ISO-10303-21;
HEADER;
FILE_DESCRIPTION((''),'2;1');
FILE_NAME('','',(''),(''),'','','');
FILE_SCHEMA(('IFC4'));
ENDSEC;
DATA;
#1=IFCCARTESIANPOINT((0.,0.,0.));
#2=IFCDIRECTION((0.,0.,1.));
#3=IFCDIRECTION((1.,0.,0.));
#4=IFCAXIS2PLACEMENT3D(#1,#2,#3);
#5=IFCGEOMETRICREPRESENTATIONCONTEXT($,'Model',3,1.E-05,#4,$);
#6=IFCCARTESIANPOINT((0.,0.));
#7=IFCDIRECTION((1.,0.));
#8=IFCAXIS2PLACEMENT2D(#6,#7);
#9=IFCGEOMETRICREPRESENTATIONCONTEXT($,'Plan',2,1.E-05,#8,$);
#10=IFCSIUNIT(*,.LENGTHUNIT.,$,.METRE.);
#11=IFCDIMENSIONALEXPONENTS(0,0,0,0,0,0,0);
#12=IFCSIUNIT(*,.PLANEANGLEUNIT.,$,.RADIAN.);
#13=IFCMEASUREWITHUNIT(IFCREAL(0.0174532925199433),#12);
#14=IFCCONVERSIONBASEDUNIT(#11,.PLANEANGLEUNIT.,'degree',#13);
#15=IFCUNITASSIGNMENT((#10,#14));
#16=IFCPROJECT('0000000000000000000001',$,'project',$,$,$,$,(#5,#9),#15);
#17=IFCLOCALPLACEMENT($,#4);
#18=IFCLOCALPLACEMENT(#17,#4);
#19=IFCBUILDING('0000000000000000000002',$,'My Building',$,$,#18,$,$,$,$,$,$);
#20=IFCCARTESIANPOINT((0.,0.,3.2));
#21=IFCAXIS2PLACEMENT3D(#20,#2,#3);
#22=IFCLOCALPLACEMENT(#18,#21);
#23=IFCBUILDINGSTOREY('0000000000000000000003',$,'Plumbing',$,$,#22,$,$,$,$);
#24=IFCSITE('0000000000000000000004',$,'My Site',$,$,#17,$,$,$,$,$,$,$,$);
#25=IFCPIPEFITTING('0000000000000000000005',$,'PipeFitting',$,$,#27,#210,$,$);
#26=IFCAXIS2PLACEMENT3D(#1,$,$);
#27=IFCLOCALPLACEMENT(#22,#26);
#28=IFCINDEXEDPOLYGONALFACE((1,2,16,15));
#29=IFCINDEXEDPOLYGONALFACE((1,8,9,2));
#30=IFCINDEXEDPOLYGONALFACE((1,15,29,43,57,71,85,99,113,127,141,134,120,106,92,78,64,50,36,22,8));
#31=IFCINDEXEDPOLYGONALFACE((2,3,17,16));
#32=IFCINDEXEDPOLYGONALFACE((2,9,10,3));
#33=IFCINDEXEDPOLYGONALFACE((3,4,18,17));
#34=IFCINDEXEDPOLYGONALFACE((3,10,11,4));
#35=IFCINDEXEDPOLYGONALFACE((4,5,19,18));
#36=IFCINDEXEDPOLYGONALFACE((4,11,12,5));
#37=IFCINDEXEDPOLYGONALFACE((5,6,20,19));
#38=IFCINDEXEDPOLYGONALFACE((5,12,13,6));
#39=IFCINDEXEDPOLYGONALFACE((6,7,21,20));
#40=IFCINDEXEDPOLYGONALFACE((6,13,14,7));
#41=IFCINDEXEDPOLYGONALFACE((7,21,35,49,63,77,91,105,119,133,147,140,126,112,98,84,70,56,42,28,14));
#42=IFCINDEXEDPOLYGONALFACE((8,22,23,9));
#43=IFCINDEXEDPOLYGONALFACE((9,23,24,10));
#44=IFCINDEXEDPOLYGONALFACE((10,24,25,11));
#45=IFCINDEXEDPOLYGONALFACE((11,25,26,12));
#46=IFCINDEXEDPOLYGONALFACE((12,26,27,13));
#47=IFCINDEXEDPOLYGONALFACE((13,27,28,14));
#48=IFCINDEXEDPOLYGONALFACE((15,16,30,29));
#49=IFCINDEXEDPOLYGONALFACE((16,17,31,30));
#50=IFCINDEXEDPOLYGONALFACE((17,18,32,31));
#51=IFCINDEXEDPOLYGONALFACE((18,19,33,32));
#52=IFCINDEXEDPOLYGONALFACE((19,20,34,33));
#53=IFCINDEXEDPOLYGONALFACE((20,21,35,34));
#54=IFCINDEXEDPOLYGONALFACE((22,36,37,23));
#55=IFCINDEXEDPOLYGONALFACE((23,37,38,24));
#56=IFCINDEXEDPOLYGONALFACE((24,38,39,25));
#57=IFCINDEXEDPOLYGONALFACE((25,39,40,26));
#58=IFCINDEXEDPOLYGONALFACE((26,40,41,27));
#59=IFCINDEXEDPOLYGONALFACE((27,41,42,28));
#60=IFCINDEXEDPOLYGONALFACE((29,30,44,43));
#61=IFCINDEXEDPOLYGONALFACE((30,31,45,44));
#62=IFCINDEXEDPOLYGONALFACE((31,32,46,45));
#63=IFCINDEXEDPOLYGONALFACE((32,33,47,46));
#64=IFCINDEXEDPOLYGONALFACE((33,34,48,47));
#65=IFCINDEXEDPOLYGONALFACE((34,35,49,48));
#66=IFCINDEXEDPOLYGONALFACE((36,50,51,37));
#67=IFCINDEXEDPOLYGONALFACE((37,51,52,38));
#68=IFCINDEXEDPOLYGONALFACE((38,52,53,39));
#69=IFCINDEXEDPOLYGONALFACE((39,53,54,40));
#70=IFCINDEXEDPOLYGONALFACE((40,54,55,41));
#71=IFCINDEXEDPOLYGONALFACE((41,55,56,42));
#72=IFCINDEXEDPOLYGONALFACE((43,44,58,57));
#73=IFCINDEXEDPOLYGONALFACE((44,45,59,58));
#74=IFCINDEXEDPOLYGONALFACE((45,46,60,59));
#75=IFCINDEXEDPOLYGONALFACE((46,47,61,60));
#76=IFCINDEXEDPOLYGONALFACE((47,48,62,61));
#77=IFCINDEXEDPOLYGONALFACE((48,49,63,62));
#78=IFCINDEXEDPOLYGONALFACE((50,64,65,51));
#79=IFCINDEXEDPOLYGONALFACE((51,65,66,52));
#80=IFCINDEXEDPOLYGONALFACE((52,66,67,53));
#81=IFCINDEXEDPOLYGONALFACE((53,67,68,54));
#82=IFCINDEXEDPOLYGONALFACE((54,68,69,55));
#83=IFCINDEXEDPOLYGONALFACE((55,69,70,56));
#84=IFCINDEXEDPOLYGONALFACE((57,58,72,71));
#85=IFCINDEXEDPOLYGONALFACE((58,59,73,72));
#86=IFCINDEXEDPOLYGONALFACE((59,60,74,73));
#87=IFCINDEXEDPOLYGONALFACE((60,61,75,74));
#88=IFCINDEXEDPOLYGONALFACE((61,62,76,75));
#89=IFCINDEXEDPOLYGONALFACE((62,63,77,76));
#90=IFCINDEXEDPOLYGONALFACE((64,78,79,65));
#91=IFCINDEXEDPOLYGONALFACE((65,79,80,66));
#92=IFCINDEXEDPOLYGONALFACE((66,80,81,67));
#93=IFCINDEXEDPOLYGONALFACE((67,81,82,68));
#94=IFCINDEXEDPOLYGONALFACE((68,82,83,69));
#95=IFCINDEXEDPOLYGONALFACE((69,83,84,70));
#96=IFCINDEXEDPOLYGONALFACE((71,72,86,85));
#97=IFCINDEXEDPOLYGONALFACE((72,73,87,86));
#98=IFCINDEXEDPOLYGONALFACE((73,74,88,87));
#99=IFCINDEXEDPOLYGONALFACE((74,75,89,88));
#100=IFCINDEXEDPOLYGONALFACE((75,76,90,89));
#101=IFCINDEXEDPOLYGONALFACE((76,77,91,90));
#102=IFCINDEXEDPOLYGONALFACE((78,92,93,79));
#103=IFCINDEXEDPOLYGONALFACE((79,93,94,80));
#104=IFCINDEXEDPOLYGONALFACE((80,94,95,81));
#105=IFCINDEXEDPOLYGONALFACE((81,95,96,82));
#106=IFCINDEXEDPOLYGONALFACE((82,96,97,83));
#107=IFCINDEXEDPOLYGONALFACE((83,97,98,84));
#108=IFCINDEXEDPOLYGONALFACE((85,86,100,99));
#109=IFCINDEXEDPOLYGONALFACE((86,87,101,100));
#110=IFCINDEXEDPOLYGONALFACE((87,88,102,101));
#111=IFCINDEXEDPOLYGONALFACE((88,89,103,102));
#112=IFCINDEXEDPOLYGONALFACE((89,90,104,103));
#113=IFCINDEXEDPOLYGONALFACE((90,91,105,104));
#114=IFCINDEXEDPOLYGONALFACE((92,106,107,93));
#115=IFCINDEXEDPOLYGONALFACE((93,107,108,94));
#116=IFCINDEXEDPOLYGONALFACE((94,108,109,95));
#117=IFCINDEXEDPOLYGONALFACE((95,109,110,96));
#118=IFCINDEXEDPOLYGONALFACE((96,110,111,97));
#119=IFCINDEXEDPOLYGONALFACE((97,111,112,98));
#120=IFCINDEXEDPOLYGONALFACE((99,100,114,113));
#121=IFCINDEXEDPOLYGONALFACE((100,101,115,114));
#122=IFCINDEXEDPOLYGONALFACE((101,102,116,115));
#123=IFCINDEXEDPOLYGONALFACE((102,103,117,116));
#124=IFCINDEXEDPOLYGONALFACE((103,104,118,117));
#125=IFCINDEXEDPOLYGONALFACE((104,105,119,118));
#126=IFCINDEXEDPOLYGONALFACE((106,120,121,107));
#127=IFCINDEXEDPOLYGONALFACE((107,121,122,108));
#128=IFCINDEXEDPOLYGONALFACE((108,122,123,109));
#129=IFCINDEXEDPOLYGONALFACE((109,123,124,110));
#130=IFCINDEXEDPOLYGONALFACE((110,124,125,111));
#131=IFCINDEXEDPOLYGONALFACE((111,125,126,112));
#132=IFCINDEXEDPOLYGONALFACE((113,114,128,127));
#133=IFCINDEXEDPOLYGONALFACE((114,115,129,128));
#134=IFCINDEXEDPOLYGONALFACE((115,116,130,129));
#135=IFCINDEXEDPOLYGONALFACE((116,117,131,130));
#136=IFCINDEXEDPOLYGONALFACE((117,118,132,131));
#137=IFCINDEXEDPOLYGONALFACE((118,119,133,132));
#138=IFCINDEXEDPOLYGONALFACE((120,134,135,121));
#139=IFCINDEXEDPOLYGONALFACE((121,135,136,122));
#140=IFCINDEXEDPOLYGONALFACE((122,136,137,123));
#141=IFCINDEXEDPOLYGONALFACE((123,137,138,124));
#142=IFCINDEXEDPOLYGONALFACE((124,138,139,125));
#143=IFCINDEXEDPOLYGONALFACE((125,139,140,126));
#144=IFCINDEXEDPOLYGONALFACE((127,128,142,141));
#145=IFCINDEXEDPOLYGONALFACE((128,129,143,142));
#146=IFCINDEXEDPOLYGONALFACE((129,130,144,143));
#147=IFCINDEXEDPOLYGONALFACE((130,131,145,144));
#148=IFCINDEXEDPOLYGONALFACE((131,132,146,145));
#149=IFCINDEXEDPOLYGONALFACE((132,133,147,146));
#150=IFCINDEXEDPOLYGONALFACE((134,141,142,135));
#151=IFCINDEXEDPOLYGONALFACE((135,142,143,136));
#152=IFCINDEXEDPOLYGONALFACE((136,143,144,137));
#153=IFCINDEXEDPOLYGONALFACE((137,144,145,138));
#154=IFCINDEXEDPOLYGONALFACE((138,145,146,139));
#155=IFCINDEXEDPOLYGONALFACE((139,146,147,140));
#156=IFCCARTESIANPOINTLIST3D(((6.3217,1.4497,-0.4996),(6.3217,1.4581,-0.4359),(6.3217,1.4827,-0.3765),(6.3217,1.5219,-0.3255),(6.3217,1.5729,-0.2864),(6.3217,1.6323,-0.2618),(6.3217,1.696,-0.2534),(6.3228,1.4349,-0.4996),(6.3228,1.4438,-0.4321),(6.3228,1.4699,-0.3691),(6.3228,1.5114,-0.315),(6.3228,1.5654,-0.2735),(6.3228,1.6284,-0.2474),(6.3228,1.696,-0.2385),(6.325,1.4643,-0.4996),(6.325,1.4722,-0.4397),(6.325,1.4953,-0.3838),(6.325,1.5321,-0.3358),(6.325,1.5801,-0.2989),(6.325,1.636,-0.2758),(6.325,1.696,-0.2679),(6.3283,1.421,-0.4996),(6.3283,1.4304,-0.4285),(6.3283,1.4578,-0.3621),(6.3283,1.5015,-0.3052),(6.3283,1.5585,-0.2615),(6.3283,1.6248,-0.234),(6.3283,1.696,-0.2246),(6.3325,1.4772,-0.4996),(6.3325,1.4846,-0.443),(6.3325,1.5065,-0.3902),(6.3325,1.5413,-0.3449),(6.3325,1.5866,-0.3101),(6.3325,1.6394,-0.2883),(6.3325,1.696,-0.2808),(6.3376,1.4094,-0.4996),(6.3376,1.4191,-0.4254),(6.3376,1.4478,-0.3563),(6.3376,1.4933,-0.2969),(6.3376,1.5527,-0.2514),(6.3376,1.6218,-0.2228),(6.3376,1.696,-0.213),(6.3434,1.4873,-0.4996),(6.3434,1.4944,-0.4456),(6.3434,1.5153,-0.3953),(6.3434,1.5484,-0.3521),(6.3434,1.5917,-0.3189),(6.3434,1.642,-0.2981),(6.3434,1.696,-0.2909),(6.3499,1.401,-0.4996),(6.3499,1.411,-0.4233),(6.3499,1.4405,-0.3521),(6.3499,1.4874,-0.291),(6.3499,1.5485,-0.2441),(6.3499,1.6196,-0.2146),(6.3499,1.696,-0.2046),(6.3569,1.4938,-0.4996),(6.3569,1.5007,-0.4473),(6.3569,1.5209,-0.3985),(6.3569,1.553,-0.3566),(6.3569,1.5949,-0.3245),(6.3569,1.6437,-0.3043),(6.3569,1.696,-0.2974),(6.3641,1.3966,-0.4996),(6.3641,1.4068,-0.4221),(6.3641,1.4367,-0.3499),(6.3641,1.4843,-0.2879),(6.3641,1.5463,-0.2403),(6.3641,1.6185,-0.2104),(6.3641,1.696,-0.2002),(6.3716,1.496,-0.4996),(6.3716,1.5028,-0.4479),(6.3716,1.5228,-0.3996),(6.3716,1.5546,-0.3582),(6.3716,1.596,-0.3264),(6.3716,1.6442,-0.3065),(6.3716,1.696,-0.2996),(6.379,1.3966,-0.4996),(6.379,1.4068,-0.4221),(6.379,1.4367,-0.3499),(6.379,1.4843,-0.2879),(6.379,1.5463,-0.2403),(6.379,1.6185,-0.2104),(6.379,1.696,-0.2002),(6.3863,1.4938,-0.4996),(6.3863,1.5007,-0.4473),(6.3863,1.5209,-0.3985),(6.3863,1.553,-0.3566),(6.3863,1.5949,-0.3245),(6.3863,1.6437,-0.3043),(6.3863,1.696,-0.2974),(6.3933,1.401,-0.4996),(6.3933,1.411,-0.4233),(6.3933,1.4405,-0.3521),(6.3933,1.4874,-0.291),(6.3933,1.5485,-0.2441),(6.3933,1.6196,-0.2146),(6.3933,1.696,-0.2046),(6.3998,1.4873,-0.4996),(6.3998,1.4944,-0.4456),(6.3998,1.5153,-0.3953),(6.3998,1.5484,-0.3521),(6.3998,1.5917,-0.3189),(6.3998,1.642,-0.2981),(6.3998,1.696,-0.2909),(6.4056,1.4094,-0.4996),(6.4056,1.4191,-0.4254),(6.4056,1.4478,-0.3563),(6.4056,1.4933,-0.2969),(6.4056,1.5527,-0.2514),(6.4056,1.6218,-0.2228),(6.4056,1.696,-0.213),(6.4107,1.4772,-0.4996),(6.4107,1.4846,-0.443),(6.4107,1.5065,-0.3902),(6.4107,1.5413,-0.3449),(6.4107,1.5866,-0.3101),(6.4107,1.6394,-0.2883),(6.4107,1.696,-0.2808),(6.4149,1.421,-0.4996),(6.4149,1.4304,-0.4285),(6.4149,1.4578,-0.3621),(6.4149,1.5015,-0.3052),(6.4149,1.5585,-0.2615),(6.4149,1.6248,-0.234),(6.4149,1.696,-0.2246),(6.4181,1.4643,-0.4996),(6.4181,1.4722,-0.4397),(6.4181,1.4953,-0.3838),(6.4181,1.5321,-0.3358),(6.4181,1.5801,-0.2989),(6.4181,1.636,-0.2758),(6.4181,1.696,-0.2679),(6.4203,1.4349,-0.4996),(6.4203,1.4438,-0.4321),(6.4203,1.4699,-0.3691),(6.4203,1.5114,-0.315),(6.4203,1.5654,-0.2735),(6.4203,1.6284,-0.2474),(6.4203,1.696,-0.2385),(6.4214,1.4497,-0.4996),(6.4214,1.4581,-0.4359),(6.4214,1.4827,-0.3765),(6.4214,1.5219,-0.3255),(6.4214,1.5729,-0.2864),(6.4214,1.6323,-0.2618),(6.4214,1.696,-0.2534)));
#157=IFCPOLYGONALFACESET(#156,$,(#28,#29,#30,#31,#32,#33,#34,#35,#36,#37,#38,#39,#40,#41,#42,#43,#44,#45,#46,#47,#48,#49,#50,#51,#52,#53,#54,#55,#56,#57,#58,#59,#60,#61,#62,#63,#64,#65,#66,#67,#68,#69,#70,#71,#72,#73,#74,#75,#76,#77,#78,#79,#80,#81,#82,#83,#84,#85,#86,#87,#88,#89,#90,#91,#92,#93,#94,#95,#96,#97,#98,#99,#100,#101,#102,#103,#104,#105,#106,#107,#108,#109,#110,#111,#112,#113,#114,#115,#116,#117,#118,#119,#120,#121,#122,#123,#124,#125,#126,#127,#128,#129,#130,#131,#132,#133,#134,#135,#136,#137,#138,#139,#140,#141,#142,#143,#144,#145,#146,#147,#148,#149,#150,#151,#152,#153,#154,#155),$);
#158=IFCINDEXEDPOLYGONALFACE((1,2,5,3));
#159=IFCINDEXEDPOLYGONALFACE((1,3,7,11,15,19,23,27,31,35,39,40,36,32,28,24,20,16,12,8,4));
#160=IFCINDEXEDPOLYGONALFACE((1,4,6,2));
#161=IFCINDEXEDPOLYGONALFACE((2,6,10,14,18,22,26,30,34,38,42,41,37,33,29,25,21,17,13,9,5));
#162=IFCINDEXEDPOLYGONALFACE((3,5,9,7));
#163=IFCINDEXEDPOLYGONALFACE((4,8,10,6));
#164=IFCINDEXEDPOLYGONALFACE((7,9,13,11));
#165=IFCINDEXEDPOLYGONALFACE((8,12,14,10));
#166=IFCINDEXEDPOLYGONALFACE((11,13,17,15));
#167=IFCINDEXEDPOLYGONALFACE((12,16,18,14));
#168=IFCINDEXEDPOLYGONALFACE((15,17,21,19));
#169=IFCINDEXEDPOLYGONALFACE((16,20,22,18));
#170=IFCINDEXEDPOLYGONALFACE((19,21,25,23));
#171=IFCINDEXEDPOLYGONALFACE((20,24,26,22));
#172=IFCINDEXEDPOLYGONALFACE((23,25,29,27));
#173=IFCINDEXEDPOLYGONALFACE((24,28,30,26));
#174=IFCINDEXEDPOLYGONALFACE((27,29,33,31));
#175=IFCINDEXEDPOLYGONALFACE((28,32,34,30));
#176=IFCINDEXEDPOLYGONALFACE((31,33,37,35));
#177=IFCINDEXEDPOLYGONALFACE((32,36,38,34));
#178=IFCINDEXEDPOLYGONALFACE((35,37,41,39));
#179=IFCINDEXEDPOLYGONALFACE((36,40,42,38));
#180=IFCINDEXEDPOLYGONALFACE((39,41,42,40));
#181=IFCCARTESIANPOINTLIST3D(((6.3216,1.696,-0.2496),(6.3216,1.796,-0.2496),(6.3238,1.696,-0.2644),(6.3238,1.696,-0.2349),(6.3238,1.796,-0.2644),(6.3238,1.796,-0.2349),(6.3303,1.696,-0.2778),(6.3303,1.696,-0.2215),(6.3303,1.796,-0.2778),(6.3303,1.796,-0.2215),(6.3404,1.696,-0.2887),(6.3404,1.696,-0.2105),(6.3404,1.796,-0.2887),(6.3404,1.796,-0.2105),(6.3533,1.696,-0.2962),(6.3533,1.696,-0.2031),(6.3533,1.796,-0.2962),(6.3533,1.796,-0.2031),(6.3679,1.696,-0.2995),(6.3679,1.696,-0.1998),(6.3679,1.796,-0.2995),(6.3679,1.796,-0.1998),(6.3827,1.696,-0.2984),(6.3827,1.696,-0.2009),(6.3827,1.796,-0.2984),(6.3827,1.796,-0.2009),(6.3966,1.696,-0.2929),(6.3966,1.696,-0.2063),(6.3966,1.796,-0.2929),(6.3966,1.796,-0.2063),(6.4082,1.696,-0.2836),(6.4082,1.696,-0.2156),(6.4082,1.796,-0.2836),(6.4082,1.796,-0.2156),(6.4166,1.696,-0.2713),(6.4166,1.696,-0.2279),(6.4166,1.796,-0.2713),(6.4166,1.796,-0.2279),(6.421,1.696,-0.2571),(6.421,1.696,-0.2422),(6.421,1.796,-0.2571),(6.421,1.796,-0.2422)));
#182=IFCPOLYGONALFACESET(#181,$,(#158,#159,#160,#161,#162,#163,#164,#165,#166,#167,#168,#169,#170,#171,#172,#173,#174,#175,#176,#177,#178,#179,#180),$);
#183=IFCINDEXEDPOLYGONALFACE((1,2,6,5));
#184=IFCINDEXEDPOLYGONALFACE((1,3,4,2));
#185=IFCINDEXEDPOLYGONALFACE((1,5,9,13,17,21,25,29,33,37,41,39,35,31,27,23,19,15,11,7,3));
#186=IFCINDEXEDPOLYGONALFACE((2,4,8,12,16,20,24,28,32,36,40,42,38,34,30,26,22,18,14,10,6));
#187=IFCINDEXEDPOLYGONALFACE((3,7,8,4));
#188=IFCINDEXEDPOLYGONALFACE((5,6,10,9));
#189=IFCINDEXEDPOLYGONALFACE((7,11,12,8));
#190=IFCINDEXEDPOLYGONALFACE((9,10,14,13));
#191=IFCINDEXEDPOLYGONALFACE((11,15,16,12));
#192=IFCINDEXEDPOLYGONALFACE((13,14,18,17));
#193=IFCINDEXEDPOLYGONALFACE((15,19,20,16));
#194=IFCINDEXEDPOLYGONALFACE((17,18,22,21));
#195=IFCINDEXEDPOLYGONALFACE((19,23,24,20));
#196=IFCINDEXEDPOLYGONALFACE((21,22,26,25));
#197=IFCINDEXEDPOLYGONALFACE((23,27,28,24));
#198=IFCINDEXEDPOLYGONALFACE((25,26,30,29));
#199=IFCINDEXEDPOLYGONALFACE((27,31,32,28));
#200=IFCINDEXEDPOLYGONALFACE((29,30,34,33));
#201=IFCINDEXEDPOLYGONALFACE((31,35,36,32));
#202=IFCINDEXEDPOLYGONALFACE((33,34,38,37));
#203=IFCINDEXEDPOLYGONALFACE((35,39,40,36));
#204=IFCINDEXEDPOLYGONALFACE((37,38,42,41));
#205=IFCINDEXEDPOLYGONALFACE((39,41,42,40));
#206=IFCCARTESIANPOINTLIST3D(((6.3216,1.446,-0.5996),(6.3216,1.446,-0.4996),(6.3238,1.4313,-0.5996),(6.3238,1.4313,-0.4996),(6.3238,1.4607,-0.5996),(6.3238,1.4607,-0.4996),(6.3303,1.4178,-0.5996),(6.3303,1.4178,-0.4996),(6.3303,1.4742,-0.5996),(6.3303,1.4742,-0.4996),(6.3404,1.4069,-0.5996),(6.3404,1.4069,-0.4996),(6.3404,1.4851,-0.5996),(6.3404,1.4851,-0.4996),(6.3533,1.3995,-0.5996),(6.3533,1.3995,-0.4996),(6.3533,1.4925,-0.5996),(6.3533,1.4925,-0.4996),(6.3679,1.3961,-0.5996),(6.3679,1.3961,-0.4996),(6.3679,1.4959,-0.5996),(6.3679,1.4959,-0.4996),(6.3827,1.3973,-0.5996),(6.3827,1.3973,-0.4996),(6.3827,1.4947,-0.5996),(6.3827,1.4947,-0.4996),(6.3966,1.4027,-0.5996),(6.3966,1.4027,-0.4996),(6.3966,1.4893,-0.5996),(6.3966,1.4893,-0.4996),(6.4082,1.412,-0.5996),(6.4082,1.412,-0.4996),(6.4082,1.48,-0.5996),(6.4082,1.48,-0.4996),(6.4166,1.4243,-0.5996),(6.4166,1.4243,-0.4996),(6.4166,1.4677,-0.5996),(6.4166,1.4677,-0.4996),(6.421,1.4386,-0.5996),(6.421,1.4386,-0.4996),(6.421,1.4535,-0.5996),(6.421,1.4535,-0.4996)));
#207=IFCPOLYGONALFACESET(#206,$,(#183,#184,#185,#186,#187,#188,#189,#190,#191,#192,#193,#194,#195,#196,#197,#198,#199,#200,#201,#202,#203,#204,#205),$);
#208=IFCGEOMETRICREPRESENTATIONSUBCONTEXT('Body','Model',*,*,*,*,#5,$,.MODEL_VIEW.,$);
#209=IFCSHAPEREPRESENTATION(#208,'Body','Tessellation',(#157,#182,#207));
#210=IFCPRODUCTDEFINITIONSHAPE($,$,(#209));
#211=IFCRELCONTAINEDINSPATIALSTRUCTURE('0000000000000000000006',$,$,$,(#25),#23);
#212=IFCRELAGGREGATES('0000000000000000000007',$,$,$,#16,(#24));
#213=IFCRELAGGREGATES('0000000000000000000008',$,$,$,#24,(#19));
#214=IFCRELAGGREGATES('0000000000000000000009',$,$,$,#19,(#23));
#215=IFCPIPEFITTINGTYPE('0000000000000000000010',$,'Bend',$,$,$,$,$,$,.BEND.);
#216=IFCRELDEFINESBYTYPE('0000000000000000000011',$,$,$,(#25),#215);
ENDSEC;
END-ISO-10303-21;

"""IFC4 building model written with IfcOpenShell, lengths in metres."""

from ifc_helpers import new_model, entity, si_unit, converted_unit, frame, origin_with_axes, origin_2d_with_axis, place, context, subcontext, project, spatial, circle, extrude, source, transform, mapped, type_object, type_shapes, element, save


model = new_model("IFC4")

# Units and contexts
model_context = context("Model", 3, precision=1e-05, world=origin_with_axes())
plan_context = context("Plan", 2, precision=1e-05, world=origin_2d_with_axis())
body_context = subcontext(model_context, "Body", "Model", "MODEL_VIEW")
ifc_project = project(units=[si_unit("LENGTHUNIT", "METRE"), converted_unit("PLANEANGLEUNIT", "degree", entity("IfcReal", 0.0174532925199433), si_unit("PLANEANGLEUNIT", "RADIAN"), dimensions=[0, 0, 0, 0, 0, 0, 0])], contexts=[model_context, plan_context])

# Site, building, storey
site_placement = place(None, origin_with_axes())
site = spatial("IfcSite", under=ifc_project, at=site_placement, Name="My Site")
building_placement = place(site_placement, origin_with_axes())
building = spatial("IfcBuilding", under=site, at=building_placement, Name="My Building")
storey_placement = place(building_placement, frame((0.0, 0.0, 3.2), z_axis=(0.0, 0.0, 1.0), x_axis=(1.0, 0.0, 0.0)))
storey = spatial("IfcBuildingStorey", under=building, at=storey_placement, Name="Plumbing")

# Pipe fitting
pipe_fitting_type = type_object("IfcPipeFittingType", Name="Bend", PredefinedType="BEND")
shared_shape = source(origin_with_axes(), body_context, "Body", "SolidModel", [
    entity("IfcSweptDiskSolid", entity("IfcIndexedPolyCurve", entity("IfcCartesianPointList3D", [[0.0, 0.0, -0.1], [0.0, -0.0732, -0.2768], [0.0, -0.25, -0.35]]), [entity("IfcArcIndex", [1, 2, 3])]), 0.05),
    extrude(circle(Radius=0.05), origin_with_axes(), (0.0, 0.0, -1.0), 0.1),
    extrude(circle(Radius=0.05), frame((0.0, -0.25, -0.35), z_axis=(0.0, -1.0, 0.0), x_axis=(1.0, 0.0, 0.0)), (0.0, 0.0, 1.0), 0.1),
])
type_shapes(pipe_fitting_type, [shared_shape])
for number, where, z_axis, x_axis, name in (
    (1, (6.3716, 1.796, -0.2496), (0.0, 1.0, 0.0), (-1.0, 0.0, 0.0), "PipeFitting"),
):
    element("IfcPipeFitting", number, at=place(storey_placement, frame(where, z_axis=z_axis, x_axis=x_axis)), inside=storey, type_object=pipe_fitting_type, Name=name, context=body_context, shape_type="MappedRepresentation", body=[
        mapped(shared_shape, transform((0.0, 0.0, 0.0), x_axis=(1.0, 0.0, 0.0), y_axis=(0.0, 1.0, 0.0), z_axis=(0.0, 0.0, 1.0), scale=1.0)),
    ])

save(model, "model.ifc")
